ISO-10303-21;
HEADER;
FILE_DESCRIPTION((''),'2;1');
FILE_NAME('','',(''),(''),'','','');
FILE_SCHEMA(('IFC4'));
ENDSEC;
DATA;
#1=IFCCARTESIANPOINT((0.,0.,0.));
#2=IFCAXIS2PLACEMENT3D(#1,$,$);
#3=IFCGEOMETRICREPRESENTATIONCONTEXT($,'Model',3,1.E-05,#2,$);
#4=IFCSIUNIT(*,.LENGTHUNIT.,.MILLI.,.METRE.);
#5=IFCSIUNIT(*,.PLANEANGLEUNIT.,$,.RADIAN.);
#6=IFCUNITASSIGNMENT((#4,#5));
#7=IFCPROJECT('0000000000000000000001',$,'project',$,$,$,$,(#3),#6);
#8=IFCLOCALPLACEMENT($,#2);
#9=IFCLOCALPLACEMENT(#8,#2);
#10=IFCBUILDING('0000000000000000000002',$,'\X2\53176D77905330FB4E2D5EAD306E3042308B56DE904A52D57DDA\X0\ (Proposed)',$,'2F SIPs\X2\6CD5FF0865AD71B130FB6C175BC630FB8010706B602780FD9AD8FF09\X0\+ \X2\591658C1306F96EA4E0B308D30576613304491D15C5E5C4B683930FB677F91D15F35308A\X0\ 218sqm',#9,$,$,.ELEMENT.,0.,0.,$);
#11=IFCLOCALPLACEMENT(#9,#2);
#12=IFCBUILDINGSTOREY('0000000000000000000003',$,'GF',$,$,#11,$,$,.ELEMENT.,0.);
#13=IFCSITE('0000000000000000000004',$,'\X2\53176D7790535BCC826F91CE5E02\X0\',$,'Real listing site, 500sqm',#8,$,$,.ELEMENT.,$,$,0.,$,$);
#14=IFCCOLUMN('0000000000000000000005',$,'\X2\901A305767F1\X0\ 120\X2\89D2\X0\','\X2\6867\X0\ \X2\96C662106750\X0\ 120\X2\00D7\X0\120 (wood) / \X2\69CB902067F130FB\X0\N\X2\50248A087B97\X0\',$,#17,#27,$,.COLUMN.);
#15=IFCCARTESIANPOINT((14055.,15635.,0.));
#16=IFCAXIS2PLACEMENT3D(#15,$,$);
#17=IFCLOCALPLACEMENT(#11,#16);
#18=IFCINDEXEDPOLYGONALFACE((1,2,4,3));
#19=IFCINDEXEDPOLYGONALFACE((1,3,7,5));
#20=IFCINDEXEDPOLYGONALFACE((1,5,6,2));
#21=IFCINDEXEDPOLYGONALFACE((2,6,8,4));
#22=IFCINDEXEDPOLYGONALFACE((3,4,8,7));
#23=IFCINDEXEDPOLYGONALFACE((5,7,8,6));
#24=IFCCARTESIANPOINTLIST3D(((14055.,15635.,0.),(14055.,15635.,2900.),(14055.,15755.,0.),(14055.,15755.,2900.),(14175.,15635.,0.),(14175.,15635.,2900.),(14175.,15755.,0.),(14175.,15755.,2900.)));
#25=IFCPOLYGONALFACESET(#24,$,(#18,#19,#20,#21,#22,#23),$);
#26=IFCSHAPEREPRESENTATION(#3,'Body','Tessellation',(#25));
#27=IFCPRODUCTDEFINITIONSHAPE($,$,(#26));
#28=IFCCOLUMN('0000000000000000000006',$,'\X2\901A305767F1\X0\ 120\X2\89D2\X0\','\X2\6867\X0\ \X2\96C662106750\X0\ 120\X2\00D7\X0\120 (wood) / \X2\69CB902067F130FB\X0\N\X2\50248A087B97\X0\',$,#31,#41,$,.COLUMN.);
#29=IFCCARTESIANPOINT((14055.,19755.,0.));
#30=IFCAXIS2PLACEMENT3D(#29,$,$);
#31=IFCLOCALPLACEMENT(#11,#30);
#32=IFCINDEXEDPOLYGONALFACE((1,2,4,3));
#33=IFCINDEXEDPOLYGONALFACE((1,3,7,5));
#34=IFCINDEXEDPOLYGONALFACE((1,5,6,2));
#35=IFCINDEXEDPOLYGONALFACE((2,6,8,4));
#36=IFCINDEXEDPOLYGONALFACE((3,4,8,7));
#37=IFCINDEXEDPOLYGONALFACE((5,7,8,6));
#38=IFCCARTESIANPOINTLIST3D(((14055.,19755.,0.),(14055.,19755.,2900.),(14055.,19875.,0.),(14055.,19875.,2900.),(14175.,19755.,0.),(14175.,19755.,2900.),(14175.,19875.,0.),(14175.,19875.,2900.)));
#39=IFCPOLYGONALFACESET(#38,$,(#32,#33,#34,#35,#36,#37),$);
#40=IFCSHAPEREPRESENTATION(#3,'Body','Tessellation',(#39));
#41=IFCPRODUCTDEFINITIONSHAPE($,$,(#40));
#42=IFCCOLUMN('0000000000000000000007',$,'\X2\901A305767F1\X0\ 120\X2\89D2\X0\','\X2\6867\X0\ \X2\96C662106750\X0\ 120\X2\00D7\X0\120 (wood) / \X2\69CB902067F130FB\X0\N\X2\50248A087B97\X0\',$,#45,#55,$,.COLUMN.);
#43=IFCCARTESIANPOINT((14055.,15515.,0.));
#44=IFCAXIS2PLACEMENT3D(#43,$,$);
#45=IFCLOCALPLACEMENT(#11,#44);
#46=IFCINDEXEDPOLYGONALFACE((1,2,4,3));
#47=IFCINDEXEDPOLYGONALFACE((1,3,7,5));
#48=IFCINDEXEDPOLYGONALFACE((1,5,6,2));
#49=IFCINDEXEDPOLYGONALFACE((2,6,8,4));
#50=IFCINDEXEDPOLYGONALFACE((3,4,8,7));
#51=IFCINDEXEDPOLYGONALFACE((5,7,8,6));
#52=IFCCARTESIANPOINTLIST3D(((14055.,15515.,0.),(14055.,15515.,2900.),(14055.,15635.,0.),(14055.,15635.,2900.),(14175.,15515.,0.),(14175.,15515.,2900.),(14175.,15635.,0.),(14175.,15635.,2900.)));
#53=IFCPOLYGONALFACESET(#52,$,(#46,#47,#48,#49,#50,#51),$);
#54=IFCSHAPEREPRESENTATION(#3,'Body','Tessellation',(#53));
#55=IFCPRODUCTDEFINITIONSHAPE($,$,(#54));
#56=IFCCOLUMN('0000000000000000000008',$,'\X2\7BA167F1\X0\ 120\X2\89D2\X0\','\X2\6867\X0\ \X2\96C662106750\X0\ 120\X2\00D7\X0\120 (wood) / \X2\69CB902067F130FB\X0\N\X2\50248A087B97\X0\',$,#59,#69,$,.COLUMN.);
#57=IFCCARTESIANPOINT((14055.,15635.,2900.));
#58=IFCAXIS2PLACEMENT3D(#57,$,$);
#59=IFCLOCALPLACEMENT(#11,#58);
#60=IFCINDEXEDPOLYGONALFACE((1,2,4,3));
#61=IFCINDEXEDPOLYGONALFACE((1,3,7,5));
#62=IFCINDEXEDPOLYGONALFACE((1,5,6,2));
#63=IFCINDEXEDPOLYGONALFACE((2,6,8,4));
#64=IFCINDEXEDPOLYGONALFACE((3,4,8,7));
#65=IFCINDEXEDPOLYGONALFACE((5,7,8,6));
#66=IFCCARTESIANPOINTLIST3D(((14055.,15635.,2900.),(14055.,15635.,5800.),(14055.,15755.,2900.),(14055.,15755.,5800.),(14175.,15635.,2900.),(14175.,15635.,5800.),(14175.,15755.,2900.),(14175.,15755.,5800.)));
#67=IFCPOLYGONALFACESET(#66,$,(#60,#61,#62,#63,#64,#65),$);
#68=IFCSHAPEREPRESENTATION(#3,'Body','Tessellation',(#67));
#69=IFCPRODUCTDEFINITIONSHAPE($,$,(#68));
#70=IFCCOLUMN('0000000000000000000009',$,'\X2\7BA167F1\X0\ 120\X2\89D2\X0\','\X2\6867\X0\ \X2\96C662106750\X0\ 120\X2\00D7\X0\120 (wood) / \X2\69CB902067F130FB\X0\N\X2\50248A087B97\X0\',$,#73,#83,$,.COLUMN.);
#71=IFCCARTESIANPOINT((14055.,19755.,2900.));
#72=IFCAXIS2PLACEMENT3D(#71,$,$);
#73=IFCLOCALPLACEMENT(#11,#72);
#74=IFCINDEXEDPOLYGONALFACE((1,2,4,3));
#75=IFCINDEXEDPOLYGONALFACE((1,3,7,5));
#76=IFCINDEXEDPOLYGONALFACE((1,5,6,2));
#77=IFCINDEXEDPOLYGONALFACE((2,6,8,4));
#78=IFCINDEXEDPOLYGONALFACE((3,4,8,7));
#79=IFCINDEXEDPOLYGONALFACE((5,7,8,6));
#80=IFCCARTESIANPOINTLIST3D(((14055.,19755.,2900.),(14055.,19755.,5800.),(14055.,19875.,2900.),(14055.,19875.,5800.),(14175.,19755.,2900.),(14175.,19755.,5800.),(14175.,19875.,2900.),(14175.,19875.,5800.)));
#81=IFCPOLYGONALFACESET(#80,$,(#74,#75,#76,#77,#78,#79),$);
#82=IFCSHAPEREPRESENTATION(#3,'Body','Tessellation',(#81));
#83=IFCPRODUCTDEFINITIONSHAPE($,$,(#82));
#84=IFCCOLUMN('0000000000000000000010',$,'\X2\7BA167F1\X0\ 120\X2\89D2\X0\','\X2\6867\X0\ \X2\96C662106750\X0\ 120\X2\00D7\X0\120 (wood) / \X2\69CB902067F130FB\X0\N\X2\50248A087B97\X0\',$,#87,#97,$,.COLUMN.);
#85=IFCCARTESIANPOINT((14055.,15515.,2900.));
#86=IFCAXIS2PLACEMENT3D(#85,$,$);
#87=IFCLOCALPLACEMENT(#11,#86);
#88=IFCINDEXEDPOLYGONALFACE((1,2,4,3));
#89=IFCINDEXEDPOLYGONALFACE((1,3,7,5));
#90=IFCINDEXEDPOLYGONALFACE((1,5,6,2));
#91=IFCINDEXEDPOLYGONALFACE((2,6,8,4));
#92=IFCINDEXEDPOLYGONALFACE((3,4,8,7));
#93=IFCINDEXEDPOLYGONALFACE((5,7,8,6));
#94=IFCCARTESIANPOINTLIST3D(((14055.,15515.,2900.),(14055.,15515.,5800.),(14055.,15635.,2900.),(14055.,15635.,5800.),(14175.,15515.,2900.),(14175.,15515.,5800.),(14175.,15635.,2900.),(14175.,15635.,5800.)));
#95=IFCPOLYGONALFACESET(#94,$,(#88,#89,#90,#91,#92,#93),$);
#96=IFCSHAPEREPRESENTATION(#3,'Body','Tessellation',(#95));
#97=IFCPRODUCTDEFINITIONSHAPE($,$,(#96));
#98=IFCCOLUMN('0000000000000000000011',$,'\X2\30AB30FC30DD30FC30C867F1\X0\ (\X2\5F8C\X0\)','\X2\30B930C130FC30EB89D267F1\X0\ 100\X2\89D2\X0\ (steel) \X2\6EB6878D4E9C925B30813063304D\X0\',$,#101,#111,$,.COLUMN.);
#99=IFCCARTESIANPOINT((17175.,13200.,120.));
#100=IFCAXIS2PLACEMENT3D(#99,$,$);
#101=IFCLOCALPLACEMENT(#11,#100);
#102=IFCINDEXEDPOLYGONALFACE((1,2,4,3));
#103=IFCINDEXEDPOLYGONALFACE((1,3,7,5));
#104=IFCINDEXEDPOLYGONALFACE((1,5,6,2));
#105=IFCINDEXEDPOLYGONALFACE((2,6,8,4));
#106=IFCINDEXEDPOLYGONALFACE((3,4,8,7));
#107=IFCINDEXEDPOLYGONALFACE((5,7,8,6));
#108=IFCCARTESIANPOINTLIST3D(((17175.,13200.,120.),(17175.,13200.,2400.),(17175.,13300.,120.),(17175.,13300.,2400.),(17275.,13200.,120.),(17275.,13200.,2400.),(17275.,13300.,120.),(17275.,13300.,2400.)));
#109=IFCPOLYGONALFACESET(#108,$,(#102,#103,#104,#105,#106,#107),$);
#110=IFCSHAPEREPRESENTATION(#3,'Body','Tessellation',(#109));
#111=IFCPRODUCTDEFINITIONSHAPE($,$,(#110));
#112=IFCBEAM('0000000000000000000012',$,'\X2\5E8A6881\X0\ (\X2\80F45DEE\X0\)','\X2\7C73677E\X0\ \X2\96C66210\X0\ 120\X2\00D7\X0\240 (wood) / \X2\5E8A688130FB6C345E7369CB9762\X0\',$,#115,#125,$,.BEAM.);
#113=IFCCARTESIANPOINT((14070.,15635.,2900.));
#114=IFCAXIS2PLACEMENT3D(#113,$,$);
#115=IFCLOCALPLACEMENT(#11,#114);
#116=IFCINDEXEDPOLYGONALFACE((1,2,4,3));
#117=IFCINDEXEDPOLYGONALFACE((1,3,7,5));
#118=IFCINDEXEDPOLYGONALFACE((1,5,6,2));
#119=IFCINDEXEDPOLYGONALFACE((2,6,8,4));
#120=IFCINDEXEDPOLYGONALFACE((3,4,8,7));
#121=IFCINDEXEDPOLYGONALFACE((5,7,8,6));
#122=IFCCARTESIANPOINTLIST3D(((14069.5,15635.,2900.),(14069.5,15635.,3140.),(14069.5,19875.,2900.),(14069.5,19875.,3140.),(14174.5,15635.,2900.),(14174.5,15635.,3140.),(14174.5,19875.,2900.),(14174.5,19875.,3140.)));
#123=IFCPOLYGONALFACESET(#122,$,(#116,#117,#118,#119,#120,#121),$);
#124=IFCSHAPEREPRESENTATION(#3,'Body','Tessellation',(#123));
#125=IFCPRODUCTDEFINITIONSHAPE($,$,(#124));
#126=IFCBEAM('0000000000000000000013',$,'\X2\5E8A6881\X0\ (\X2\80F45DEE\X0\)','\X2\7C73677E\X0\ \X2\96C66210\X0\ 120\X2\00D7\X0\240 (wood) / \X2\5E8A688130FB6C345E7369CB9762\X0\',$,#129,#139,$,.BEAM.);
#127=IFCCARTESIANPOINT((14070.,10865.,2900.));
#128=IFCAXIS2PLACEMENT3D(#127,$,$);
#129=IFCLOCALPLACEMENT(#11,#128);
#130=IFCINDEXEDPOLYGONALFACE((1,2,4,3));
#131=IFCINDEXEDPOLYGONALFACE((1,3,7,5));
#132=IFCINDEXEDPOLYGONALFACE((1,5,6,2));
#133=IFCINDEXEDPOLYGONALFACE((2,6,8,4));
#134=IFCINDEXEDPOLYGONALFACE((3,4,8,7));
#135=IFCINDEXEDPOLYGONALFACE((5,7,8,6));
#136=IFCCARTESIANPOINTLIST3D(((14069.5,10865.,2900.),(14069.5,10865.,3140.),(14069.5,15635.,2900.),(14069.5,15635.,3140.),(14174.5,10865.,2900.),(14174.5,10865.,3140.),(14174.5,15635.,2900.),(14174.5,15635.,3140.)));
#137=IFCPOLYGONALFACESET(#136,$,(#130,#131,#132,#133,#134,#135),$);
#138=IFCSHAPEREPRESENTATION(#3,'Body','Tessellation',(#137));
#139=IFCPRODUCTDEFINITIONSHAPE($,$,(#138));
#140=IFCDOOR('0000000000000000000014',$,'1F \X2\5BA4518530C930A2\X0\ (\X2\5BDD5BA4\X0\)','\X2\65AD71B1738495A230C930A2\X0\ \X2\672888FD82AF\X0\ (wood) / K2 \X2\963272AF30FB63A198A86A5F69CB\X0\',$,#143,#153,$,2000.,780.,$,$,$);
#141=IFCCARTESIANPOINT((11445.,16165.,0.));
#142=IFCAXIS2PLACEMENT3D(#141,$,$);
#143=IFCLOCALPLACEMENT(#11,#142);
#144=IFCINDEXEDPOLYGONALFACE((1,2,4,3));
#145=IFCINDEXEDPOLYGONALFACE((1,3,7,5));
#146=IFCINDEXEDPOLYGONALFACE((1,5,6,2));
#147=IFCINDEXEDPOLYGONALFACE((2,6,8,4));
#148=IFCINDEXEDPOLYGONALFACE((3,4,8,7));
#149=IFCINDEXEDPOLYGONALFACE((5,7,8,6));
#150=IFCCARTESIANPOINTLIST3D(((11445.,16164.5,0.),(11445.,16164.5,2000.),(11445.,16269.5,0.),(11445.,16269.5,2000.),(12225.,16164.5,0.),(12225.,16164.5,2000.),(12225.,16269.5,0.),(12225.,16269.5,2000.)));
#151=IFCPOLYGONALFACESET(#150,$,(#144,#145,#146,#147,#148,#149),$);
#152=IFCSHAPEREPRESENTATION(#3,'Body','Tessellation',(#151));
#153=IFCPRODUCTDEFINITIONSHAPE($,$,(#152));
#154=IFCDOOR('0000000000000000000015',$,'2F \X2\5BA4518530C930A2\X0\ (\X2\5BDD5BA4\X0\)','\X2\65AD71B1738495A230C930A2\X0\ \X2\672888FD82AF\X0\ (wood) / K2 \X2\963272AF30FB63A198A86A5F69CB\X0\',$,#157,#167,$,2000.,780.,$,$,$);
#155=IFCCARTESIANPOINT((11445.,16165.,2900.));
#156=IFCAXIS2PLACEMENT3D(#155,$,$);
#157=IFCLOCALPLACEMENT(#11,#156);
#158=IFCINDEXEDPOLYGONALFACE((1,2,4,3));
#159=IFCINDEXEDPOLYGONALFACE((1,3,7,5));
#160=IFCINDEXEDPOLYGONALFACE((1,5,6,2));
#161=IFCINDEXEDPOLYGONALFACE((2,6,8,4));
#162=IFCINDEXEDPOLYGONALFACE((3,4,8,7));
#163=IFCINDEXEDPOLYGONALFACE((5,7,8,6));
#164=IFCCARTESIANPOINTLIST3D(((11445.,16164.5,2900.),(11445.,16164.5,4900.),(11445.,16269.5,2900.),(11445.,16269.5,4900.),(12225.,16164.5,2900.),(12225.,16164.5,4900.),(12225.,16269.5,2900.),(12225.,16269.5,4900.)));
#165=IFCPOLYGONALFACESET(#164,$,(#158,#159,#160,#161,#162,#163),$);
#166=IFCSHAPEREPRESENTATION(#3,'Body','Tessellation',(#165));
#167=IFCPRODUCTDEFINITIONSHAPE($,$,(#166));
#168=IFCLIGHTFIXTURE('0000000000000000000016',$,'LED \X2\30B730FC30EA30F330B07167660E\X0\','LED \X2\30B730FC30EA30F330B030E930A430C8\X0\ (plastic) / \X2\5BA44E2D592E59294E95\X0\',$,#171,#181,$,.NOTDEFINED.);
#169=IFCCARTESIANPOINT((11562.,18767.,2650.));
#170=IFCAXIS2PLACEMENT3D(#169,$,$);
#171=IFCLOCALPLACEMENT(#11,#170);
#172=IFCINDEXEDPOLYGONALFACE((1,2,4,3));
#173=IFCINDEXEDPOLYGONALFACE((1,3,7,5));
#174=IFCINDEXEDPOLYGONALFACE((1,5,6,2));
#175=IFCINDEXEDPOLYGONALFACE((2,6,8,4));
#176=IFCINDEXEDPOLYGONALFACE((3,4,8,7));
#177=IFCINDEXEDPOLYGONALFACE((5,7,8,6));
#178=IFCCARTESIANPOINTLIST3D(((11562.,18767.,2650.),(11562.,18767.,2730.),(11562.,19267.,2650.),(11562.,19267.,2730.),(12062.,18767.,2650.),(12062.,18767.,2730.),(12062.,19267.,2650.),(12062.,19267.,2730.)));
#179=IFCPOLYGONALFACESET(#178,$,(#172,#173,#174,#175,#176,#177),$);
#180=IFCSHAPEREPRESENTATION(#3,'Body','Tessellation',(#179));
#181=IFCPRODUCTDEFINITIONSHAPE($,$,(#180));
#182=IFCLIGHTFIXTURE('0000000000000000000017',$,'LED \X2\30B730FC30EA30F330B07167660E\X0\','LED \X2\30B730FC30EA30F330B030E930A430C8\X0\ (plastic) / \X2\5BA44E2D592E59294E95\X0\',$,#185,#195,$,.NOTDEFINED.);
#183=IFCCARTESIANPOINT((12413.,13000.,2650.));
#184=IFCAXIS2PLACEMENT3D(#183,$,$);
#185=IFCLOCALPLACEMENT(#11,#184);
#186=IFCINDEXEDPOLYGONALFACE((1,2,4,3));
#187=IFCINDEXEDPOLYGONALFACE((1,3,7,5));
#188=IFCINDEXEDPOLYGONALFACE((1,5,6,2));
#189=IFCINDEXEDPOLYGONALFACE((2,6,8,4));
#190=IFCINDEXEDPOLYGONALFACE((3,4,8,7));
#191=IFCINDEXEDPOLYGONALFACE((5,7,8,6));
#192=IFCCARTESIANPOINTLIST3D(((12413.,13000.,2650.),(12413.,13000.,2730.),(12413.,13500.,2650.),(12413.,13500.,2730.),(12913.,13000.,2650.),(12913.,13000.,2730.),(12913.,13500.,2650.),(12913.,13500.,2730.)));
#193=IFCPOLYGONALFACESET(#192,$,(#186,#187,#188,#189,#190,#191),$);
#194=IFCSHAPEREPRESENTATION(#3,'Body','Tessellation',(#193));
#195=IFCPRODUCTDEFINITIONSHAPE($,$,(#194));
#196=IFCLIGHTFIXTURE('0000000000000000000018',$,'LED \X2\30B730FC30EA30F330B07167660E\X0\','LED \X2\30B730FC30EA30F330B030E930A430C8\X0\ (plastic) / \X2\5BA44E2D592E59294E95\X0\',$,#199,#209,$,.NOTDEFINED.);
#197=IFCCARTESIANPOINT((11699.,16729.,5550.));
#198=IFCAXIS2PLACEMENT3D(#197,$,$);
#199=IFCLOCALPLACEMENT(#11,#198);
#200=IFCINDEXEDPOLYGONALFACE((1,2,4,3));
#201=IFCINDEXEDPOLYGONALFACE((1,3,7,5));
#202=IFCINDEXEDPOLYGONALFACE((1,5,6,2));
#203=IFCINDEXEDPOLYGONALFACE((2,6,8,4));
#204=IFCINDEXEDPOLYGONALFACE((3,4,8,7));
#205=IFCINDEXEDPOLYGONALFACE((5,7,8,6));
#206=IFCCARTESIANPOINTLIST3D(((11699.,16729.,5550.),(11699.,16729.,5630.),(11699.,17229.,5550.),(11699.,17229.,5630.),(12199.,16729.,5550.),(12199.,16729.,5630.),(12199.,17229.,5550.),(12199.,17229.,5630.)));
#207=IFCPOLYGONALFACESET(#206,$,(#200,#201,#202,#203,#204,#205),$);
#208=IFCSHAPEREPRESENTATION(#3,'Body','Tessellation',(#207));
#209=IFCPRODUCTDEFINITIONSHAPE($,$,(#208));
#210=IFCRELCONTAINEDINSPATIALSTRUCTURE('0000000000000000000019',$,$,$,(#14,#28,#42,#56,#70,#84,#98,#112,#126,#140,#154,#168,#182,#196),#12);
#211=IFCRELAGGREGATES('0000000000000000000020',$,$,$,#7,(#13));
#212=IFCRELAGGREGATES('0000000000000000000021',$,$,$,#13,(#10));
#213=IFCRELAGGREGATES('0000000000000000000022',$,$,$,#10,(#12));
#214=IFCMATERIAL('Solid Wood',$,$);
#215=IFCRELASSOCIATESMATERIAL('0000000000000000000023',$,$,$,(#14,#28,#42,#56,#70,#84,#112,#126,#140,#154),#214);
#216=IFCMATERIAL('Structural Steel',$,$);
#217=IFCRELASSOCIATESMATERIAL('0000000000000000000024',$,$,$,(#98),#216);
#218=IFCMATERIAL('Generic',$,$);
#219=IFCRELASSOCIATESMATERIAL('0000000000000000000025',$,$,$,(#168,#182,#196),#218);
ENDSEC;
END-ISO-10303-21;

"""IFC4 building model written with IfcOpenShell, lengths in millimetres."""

from ifc_helpers import new_model, si_unit, frame, frame_2d, origin, place, context, project, spatial, rectangle, extrude, material, element, save


model = new_model("IFC4")

# Units and contexts
model_context = context("Model", 3, precision=1e-05, world=origin())
ifc_project = project(units=[si_unit("LENGTHUNIT", "METRE", prefix="MILLI"), si_unit("PLANEANGLEUNIT", "RADIAN")], contexts=[model_context])

# Site, building, storey
site_placement = place(None, origin())
site = spatial("IfcSite", under=ifc_project, at=site_placement, Name="北海道富良野市", ObjectType="Real listing site, 500sqm", CompositionType="ELEMENT", RefElevation=0.0)
building_placement = place(site_placement, origin())
building = spatial("IfcBuilding", under=site, at=building_placement, Name="北海道・中庭のある回遊動線 (Proposed)", ObjectType="2F SIPs法（断熱・気密・耐火性能高）+ 外壁は雪下ろし易い金属屋根・板金張り 218sqm", CompositionType="ELEMENT", ElevationOfRefHeight=0.0, ElevationOfTerrain=0.0)
storey_placement = place(building_placement, origin())
storey = spatial("IfcBuildingStorey", under=building, at=storey_placement, Name="GF", CompositionType="ELEMENT", Elevation=0.0)

# Columns
ifc_material_1 = material(Name="Solid Wood")
column_1_placement = place(storey_placement, frame((14055.0, 15635.0, 0.0)))
element("IfcColumn", 1, at=column_1_placement, inside=storey, material=ifc_material_1, Name="通し柱 120角", Description="桧 集成材 120×120 (wood) / 構造柱・N値計算", PredefinedType="COLUMN", context=model_context, shape_type="SweptSolid", body=[
    extrude(rectangle(XDim=120.0, YDim=120.0, at=frame_2d((60.0, 60.0))), frame((14055.0, 15635.0, 0.0)), (0.0, 0.0, 1.0), 2900.0),
])
column_2_placement = place(storey_placement, frame((14055.0, 19755.0, 0.0)))
element("IfcColumn", 2, at=column_2_placement, inside=storey, material=ifc_material_1, Name="通し柱 120角", Description="桧 集成材 120×120 (wood) / 構造柱・N値計算", PredefinedType="COLUMN", context=model_context, shape_type="SweptSolid", body=[
    extrude(rectangle(XDim=120.0, YDim=120.0, at=frame_2d((60.0, 60.0))), frame((14055.0, 19755.0, 0.0)), (0.0, 0.0, 1.0), 2900.0),
])
column_3_placement = place(storey_placement, frame((14055.0, 15515.0, 0.0)))
element("IfcColumn", 3, at=column_3_placement, inside=storey, material=ifc_material_1, Name="通し柱 120角", Description="桧 集成材 120×120 (wood) / 構造柱・N値計算", PredefinedType="COLUMN", context=model_context, shape_type="SweptSolid", body=[
    extrude(rectangle(XDim=120.0, YDim=120.0, at=frame_2d((60.0, 60.0))), frame((14055.0, 15515.0, 0.0)), (0.0, 0.0, 1.0), 2900.0),
])
column_4_placement = place(storey_placement, frame((14055.0, 15635.0, 2900.0)))
element("IfcColumn", 4, at=column_4_placement, inside=storey, material=ifc_material_1, Name="管柱 120角", Description="桧 集成材 120×120 (wood) / 構造柱・N値計算", PredefinedType="COLUMN", context=model_context, shape_type="SweptSolid", body=[
    extrude(rectangle(XDim=120.0, YDim=120.0, at=frame_2d((60.0, 60.0))), frame((14055.0, 15635.0, 2900.0)), (0.0, 0.0, 1.0), 2900.0),
])
column_5_placement = place(storey_placement, frame((14055.0, 19755.0, 2900.0)))
element("IfcColumn", 5, at=column_5_placement, inside=storey, material=ifc_material_1, Name="管柱 120角", Description="桧 集成材 120×120 (wood) / 構造柱・N値計算", PredefinedType="COLUMN", context=model_context, shape_type="SweptSolid", body=[
    extrude(rectangle(XDim=120.0, YDim=120.0, at=frame_2d((60.0, 60.0))), frame((14055.0, 19755.0, 2900.0)), (0.0, 0.0, 1.0), 2900.0),
])
column_6_placement = place(storey_placement, frame((14055.0, 15515.0, 2900.0)))
element("IfcColumn", 6, at=column_6_placement, inside=storey, material=ifc_material_1, Name="管柱 120角", Description="桧 集成材 120×120 (wood) / 構造柱・N値計算", PredefinedType="COLUMN", context=model_context, shape_type="SweptSolid", body=[
    extrude(rectangle(XDim=120.0, YDim=120.0, at=frame_2d((60.0, 60.0))), frame((14055.0, 15515.0, 2900.0)), (0.0, 0.0, 1.0), 2900.0),
])
ifc_material_2 = material(Name="Structural Steel")
column_7_placement = place(storey_placement, frame((17175.0, 13200.0, 120.0)))
element("IfcColumn", 7, at=column_7_placement, inside=storey, material=ifc_material_2, Name="カーポート柱 (後)", Description="スチール角柱 100角 (steel) 溶融亜鉛めっき", PredefinedType="COLUMN", context=model_context, shape_type="SweptSolid", body=[
    extrude(rectangle(XDim=100.0, YDim=100.0, at=frame_2d((50.0, 50.0))), frame((17175.0, 13200.0, 120.0)), (0.0, 0.0, 1.0), 2280.0),
])

# Beams
beam_1_placement = place(storey_placement, frame((14070.0, 15635.0, 2900.0)))
element("IfcBeam", 8, at=beam_1_placement, inside=storey, material=ifc_material_1, Name="床梁 (胴差)", Description="米松 集成 120×240 (wood) / 床梁・水平構面", PredefinedType="BEAM", context=model_context, shape_type="SweptSolid", body=[
    extrude(rectangle(XDim=105.0, YDim=4240.0, at=frame_2d((52.0, 2120.0))), frame((14070.0, 15635.0, 2900.0)), (0.0, 0.0, 1.0), 240.0),
])
beam_2_placement = place(storey_placement, frame((14070.0, 10865.0, 2900.0)))
element("IfcBeam", 9, at=beam_2_placement, inside=storey, material=ifc_material_1, Name="床梁 (胴差)", Description="米松 集成 120×240 (wood) / 床梁・水平構面", PredefinedType="BEAM", context=model_context, shape_type="SweptSolid", body=[
    extrude(rectangle(XDim=105.0, YDim=4770.0, at=frame_2d((52.0, 2385.0))), frame((14070.0, 10865.0, 2900.0)), (0.0, 0.0, 1.0), 240.0),
])

# Doors
door_1_placement = place(storey_placement, frame((11445.0, 16165.0, 0.0)))
element("IfcDoor", 10, at=door_1_placement, inside=storey, material=ifc_material_1, Name="1F 室内ドア (寝室)", Description="断熱玄関ドア 木製芯 (wood) / K2 防犯・採風機構", OverallHeight=2000.0, OverallWidth=780.0, context=model_context, shape_type="SweptSolid", body=[
    extrude(rectangle(XDim=780.0, YDim=105.0, at=frame_2d((390.0, 52.0))), frame((11445.0, 16165.0, 0.0)), (0.0, 0.0, 1.0), 2000.0),
])
door_2_placement = place(storey_placement, frame((11445.0, 16165.0, 2900.0)))
element("IfcDoor", 11, at=door_2_placement, inside=storey, material=ifc_material_1, Name="2F 室内ドア (寝室)", Description="断熱玄関ドア 木製芯 (wood) / K2 防犯・採風機構", OverallHeight=2000.0, OverallWidth=780.0, context=model_context, shape_type="SweptSolid", body=[
    extrude(rectangle(XDim=780.0, YDim=105.0, at=frame_2d((390.0, 52.0))), frame((11445.0, 16165.0, 2900.0)), (0.0, 0.0, 1.0), 2000.0),
])

# Light fixtures
ifc_material_3 = material(Name="Generic")
light_fixture_1_placement = place(storey_placement, frame((11562.0, 18767.0, 2650.0)))
element("IfcLightFixture", 12, at=light_fixture_1_placement, inside=storey, material=ifc_material_3, Name="LED シーリング照明", Description="LED シーリングライト (plastic) / 室中央天井", PredefinedType="NOTDEFINED", context=model_context, shape_type="SweptSolid", body=[
    extrude(rectangle(XDim=500.0, YDim=500.0, at=frame_2d((250.0, 250.0))), frame((11562.0, 18767.0, 2650.0)), (0.0, 0.0, 1.0), 80.0),
])
light_fixture_2_placement = place(storey_placement, frame((12413.0, 13000.0, 2650.0)))
element("IfcLightFixture", 13, at=light_fixture_2_placement, inside=storey, material=ifc_material_3, Name="LED シーリング照明", Description="LED シーリングライト (plastic) / 室中央天井", PredefinedType="NOTDEFINED", context=model_context, shape_type="SweptSolid", body=[
    extrude(rectangle(XDim=500.0, YDim=500.0, at=frame_2d((250.0, 250.0))), frame((12413.0, 13000.0, 2650.0)), (0.0, 0.0, 1.0), 80.0),
])
light_fixture_3_placement = place(storey_placement, frame((11699.0, 16729.0, 5550.0)))
element("IfcLightFixture", 14, at=light_fixture_3_placement, inside=storey, material=ifc_material_3, Name="LED シーリング照明", Description="LED シーリングライト (plastic) / 室中央天井", PredefinedType="NOTDEFINED", context=model_context, shape_type="SweptSolid", body=[
    extrude(rectangle(XDim=500.0, YDim=500.0, at=frame_2d((250.0, 250.0))), frame((11699.0, 16729.0, 5550.0)), (0.0, 0.0, 1.0), 80.0),
])

save(model, "model.ifc")
